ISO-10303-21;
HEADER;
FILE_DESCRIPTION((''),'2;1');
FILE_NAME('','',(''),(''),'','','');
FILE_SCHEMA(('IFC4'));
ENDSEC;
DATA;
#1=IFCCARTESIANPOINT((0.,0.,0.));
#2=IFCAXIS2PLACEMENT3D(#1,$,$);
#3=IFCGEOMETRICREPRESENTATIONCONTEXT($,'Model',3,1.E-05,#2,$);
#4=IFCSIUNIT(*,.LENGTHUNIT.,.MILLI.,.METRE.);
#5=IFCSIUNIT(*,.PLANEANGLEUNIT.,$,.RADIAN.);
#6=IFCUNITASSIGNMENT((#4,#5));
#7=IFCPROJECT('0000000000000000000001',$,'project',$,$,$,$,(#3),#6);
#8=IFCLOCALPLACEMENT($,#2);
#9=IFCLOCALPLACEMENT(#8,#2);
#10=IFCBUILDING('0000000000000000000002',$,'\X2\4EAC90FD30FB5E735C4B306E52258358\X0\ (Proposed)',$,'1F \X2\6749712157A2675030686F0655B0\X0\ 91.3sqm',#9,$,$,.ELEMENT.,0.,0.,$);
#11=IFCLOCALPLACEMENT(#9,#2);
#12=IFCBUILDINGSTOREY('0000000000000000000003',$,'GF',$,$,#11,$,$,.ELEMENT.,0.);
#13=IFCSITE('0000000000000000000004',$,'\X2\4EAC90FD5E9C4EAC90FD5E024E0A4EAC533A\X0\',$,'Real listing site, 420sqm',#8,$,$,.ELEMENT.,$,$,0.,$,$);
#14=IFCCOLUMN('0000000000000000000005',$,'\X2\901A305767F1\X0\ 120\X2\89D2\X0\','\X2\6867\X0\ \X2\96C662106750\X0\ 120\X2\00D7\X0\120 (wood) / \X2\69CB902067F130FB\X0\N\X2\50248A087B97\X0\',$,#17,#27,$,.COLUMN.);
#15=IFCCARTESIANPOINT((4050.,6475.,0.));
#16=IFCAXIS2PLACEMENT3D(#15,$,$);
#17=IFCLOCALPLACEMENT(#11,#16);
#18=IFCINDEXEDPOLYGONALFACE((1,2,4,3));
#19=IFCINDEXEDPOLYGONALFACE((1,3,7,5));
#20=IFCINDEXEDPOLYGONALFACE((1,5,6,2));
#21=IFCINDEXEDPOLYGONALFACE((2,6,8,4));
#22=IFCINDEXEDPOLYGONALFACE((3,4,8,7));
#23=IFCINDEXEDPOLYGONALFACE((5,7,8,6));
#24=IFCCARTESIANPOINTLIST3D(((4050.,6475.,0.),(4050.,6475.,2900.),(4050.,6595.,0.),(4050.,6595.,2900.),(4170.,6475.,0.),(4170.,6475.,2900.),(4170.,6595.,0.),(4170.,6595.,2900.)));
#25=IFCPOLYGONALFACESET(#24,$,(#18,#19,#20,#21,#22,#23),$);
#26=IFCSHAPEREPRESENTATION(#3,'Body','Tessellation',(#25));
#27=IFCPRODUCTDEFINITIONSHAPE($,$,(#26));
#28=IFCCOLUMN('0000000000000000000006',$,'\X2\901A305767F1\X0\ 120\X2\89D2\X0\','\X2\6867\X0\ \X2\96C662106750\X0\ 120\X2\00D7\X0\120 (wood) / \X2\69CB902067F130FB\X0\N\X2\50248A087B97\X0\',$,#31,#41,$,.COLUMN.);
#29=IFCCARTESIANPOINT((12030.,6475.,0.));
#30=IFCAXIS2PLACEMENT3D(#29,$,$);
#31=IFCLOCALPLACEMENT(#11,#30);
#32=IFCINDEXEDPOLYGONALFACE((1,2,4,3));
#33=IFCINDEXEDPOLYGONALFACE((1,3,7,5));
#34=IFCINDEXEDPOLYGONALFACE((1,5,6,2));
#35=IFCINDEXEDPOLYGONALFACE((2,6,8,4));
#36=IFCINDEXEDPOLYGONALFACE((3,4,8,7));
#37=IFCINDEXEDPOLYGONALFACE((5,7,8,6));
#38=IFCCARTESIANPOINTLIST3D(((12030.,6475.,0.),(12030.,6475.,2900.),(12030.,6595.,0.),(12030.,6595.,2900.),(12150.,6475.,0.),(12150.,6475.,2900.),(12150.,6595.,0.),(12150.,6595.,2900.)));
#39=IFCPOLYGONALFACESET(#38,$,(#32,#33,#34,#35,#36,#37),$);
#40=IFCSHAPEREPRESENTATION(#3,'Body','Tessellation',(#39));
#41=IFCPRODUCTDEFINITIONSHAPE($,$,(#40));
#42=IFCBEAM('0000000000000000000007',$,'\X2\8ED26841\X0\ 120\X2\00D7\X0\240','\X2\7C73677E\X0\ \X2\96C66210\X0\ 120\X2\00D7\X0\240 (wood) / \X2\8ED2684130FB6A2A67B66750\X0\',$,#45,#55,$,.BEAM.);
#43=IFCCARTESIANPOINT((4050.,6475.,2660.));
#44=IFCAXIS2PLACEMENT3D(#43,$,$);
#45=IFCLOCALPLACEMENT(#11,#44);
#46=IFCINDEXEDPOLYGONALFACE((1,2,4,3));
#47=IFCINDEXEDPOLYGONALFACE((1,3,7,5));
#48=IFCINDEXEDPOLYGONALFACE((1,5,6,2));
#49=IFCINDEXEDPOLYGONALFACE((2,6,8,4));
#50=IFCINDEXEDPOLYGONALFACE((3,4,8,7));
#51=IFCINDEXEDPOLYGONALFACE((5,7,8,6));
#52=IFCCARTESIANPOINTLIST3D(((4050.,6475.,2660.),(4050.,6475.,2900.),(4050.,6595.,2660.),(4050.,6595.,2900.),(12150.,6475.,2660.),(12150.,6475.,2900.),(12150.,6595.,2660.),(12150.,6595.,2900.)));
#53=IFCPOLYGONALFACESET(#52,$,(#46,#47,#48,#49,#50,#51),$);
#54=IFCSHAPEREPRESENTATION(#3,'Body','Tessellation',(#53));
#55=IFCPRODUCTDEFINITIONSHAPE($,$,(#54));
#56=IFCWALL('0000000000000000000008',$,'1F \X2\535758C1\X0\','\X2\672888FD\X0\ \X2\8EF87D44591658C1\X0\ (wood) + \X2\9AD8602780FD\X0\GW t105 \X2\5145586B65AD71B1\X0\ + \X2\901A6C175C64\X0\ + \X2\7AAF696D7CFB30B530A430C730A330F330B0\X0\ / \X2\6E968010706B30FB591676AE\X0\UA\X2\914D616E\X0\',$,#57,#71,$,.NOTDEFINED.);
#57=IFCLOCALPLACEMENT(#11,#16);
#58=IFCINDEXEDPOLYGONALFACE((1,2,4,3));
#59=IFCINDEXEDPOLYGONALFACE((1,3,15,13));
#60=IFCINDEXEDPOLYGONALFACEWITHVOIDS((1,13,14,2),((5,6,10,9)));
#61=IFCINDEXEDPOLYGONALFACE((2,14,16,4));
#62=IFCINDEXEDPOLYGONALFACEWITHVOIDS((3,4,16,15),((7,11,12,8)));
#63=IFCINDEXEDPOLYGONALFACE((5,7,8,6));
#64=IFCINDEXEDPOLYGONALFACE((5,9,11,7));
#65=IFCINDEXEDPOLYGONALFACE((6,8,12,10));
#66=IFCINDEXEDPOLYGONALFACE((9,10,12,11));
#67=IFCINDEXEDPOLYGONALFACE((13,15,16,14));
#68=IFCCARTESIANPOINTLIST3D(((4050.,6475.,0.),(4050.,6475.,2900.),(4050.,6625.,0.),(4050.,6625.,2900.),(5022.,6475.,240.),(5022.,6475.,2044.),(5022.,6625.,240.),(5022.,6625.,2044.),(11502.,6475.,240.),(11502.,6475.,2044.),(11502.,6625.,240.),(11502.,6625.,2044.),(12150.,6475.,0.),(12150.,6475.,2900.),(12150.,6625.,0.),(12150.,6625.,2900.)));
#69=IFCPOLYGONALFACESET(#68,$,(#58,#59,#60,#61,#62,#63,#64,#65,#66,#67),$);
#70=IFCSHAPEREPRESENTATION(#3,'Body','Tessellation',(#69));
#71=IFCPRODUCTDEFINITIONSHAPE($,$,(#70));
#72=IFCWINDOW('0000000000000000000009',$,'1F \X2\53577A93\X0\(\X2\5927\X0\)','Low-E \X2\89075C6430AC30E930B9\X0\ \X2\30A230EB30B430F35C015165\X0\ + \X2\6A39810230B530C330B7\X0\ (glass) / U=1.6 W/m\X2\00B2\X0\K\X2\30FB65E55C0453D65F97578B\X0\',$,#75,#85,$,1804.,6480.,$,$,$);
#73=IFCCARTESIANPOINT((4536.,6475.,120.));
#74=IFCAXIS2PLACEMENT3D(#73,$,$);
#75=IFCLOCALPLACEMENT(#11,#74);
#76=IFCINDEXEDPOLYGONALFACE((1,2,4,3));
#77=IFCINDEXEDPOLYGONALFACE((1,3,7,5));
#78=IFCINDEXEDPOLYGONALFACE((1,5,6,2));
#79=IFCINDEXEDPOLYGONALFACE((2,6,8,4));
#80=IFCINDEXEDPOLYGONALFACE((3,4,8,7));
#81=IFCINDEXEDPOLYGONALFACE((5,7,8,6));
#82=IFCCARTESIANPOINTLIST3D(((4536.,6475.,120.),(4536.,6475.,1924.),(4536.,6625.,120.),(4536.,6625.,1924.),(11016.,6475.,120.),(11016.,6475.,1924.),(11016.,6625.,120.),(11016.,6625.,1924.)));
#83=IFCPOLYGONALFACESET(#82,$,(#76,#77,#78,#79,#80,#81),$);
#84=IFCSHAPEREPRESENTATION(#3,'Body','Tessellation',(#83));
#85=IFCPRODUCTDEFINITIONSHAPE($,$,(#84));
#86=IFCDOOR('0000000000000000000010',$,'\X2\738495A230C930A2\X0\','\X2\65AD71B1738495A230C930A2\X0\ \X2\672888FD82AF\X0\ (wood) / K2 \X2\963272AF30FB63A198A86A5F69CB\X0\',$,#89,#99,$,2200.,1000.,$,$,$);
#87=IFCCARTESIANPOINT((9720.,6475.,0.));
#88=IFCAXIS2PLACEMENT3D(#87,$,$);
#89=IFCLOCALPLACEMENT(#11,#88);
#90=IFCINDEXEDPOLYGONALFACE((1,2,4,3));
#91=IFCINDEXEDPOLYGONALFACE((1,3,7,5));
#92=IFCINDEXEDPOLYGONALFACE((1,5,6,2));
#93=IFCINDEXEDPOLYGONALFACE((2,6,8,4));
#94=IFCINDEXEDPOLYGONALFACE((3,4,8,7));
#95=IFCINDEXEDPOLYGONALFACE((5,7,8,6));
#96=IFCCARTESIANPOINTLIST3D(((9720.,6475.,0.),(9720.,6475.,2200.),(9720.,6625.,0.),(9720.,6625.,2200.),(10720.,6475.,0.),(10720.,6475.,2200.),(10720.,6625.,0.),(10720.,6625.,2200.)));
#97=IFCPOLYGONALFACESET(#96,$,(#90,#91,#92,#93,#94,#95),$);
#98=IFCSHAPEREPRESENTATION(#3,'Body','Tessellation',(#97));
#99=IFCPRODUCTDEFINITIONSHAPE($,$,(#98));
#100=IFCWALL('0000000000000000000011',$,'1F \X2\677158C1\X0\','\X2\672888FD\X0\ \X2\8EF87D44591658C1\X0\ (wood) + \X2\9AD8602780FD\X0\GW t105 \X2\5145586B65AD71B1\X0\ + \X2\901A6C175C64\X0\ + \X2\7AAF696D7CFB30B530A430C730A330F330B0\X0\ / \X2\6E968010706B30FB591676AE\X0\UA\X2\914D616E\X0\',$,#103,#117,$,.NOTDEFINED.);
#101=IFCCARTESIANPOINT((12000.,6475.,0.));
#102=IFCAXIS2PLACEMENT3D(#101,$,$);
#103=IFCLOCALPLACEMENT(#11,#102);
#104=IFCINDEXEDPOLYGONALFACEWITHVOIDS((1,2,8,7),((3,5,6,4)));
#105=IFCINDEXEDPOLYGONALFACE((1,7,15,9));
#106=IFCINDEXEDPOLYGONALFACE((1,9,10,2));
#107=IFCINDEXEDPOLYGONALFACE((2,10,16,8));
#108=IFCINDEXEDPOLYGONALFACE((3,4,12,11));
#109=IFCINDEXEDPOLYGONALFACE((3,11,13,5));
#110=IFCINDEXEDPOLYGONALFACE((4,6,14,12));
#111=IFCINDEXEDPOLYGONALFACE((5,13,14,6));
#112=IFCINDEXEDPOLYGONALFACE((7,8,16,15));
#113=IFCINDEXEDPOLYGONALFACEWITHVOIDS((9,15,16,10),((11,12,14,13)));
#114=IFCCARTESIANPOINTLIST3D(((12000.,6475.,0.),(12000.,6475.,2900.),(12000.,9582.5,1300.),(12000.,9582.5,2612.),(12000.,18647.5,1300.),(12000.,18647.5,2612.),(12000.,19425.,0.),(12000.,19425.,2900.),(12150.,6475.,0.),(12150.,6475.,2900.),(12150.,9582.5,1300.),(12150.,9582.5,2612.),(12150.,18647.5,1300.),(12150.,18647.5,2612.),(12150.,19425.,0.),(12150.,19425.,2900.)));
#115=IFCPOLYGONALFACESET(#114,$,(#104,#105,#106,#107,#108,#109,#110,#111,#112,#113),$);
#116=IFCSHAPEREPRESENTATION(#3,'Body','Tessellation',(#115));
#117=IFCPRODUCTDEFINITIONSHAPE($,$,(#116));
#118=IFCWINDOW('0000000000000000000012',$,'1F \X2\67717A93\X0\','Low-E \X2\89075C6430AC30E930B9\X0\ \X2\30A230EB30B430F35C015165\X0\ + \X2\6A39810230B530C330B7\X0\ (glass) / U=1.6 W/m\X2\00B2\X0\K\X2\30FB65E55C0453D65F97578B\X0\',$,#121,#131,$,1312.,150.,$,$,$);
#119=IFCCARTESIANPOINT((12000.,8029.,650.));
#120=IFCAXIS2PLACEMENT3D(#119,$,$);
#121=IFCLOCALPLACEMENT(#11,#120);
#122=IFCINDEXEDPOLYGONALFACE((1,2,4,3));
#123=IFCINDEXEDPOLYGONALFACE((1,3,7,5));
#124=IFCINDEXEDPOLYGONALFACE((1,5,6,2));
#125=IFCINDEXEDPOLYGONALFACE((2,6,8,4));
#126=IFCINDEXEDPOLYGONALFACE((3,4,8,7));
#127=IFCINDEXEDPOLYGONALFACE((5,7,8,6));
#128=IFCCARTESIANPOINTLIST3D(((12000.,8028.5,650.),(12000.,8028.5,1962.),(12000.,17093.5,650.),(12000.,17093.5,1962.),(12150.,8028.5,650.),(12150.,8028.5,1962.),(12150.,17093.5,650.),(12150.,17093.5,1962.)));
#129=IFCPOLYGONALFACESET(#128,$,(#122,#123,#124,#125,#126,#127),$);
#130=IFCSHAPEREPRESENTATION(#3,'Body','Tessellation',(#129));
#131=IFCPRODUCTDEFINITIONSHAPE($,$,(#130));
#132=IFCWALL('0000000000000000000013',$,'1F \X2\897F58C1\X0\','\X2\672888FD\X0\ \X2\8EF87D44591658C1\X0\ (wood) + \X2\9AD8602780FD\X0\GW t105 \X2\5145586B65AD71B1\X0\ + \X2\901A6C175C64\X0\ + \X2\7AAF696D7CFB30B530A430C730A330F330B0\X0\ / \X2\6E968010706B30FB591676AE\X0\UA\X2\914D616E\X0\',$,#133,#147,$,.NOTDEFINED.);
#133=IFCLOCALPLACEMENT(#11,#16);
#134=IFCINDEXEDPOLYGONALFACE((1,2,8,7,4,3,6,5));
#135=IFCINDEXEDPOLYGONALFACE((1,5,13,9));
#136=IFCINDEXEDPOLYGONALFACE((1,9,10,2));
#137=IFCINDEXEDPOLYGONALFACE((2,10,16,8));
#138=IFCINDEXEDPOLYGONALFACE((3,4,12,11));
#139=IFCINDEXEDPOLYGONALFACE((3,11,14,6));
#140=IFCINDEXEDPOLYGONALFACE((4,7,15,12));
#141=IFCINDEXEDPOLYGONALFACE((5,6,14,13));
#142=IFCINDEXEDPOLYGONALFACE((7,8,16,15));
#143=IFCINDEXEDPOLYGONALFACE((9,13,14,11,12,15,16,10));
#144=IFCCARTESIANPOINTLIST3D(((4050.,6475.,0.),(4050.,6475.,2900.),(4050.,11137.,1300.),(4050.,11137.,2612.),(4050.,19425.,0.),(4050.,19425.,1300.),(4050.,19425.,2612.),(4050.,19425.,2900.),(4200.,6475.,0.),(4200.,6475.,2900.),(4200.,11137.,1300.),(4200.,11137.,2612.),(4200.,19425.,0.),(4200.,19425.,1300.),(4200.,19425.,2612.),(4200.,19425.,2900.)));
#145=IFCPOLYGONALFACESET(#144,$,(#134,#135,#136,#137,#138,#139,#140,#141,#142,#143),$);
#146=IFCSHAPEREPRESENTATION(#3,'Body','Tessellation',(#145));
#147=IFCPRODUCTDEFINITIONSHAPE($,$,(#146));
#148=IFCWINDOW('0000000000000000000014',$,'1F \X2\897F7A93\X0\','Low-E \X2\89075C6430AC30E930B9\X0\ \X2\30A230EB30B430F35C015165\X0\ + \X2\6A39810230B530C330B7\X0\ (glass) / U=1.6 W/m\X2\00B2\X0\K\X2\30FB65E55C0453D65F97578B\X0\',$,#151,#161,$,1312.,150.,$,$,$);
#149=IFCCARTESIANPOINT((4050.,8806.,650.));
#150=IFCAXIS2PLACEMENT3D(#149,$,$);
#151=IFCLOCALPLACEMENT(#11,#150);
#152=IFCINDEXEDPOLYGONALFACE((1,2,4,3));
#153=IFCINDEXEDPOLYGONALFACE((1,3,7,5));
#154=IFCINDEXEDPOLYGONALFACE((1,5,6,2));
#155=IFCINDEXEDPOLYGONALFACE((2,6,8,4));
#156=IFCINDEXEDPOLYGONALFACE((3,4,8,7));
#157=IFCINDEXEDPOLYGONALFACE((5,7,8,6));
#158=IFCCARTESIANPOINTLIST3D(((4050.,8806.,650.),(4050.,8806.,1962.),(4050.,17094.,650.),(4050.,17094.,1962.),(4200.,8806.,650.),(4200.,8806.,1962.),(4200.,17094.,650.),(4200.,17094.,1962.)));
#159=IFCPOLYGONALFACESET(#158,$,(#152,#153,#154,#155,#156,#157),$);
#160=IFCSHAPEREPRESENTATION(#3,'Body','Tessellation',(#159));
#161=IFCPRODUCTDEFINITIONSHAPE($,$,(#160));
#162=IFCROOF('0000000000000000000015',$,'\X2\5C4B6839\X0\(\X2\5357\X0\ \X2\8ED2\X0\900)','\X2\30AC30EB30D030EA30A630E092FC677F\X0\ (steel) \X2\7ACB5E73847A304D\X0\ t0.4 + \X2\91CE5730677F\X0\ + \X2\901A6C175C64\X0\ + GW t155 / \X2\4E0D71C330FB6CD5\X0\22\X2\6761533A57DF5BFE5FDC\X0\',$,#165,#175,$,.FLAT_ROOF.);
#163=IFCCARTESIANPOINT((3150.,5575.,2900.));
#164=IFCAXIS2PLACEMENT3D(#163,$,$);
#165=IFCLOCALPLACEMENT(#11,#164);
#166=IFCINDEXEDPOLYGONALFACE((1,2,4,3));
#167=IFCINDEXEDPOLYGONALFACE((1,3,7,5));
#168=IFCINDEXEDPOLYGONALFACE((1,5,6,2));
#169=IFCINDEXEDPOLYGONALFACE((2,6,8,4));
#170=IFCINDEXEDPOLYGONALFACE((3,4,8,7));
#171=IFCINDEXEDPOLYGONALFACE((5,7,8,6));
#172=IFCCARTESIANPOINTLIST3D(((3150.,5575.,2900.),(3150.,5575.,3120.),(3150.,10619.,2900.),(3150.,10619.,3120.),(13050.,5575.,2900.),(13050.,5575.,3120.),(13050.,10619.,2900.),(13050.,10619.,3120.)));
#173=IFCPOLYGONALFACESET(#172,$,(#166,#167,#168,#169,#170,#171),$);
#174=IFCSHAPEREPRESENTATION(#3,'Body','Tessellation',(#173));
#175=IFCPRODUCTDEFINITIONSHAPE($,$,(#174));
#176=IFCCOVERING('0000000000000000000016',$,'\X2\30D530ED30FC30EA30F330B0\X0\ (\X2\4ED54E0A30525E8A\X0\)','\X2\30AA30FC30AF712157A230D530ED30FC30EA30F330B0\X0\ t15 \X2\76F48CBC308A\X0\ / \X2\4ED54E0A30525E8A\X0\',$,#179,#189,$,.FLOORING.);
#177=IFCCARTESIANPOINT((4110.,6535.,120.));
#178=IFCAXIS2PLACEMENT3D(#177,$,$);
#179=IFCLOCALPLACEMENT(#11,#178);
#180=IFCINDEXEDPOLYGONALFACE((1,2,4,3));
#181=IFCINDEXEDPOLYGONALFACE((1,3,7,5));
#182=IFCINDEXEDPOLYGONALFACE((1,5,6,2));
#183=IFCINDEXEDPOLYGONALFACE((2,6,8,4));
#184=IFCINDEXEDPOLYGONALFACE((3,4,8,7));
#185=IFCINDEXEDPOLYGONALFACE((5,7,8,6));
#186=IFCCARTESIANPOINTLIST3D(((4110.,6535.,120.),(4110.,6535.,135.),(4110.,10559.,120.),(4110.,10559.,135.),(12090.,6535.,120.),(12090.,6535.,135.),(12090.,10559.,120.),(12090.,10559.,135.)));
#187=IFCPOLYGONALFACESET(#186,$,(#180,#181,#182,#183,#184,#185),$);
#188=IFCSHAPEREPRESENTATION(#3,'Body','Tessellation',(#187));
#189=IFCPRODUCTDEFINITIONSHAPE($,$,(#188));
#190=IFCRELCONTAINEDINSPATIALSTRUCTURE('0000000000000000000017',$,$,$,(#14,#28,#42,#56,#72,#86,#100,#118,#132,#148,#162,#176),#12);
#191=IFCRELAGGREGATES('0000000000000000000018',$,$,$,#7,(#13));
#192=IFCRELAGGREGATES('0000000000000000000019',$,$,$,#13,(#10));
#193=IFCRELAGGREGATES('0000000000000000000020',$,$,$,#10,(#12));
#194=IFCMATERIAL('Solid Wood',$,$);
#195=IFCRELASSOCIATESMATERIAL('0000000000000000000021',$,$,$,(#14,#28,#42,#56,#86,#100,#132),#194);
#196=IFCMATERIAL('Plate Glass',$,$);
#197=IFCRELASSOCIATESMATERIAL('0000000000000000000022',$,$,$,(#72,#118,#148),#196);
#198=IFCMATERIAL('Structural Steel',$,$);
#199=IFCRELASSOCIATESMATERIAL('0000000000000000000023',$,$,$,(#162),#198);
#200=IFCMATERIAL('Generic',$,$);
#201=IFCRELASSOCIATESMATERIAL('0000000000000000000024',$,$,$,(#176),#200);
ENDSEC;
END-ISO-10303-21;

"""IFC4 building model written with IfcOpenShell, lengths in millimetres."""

from ifc_helpers import new_model, si_unit, frame, frame_2d, origin, place, context, project, spatial, rectangle, extrude, material, element, fill, save


model = new_model("IFC4")

# Units and contexts
model_context = context("Model", 3, precision=1e-05, world=origin())
ifc_project = project(units=[si_unit("LENGTHUNIT", "METRE", prefix="MILLI"), si_unit("PLANEANGLEUNIT", "RADIAN")], contexts=[model_context])

# Site, building, storey
site_placement = place(None, origin())
site = spatial("IfcSite", under=ifc_project, at=site_placement, Name="京都府京都市上京区", ObjectType="Real listing site, 420sqm", CompositionType="ELEMENT", RefElevation=0.0)
building_placement = place(site_placement, origin())
building = spatial("IfcBuilding", under=site, at=building_placement, Name="京都・平屋の別荘 (Proposed)", ObjectType="1F 杉無垢材と漆喰 91.3sqm", CompositionType="ELEMENT", ElevationOfRefHeight=0.0, ElevationOfTerrain=0.0)
storey_placement = place(building_placement, origin())
storey = spatial("IfcBuildingStorey", under=building, at=storey_placement, Name="GF", CompositionType="ELEMENT", Elevation=0.0)

# Columns
ifc_material_1 = material(Name="Solid Wood")
column_1_placement = place(storey_placement, frame((4050.0, 6475.0, 0.0)))
element("IfcColumn", 1, at=column_1_placement, inside=storey, material=ifc_material_1, Name="通し柱 120角", Description="桧 集成材 120×120 (wood) / 構造柱・N値計算", PredefinedType="COLUMN", context=model_context, shape_type="SweptSolid", body=[
    extrude(rectangle(XDim=120.0, YDim=120.0, at=frame_2d((60.0, 60.0))), frame((4050.0, 6475.0, 0.0)), (0.0, 0.0, 1.0), 2900.0),
])
column_2_placement = place(storey_placement, frame((12030.0, 6475.0, 0.0)))
element("IfcColumn", 2, at=column_2_placement, inside=storey, material=ifc_material_1, Name="通し柱 120角", Description="桧 集成材 120×120 (wood) / 構造柱・N値計算", PredefinedType="COLUMN", context=model_context, shape_type="SweptSolid", body=[
    extrude(rectangle(XDim=120.0, YDim=120.0, at=frame_2d((60.0, 60.0))), frame((12030.0, 6475.0, 0.0)), (0.0, 0.0, 1.0), 2900.0),
])

# Beam
beam_1_placement = place(storey_placement, frame((4050.0, 6475.0, 2660.0)))
element("IfcBeam", 3, at=beam_1_placement, inside=storey, material=ifc_material_1, Name="軒桁 120×240", Description="米松 集成 120×240 (wood) / 軒桁・横架材", PredefinedType="BEAM", context=model_context, shape_type="SweptSolid", body=[
    extrude(rectangle(XDim=8100.0, YDim=120.0, at=frame_2d((4050.0, 60.0))), frame((4050.0, 6475.0, 2660.0)), (0.0, 0.0, 1.0), 240.0),
])

# Wall, openings, window, door
wall_1_placement = place(storey_placement, frame((4050.0, 6475.0, 0.0)))
wall_1 = element("IfcWall", 4, at=wall_1_placement, inside=storey, material=ifc_material_1, Name="1F 南壁", Description="木製 軸組外壁 (wood) + 高性能GW t105 充填断熱 + 通気層 + 窯業系サイディング / 準耐火・外皮UA配慮", PredefinedType="NOTDEFINED", context=model_context, shape_type="SweptSolid", body=[
    extrude(rectangle(XDim=8100.0, YDim=150.0, at=frame_2d((4050.0, 75.0))), frame((4050.0, 6475.0, 0.0)), (0.0, 0.0, 1.0), 2900.0),
])
opening_1_placement = place(storey_placement, frame((4536.0, 6475.0, 120.0)))
opening_1 = element("IfcOpeningElement", 5, at=opening_1_placement, cuts=wall_1, PredefinedType="NOTDEFINED", context=model_context, shape_type="SweptSolid", body=[
    extrude(rectangle(XDim=6480.0, YDim=150.0, at=frame_2d((3240.0, 75.0))), frame((4536.0, 6475.0, 120.0)), (0.0, 0.0, 1.0), 1804.0),
])
opening_2_placement = place(storey_placement, frame((9720.0, 6475.0, 0.0)))
opening_2 = element("IfcOpeningElement", 6, at=opening_2_placement, cuts=wall_1, PredefinedType="NOTDEFINED", context=model_context, shape_type="SweptSolid", body=[
    extrude(rectangle(XDim=1000.0, YDim=150.0, at=frame_2d((500.0, 75.0))), frame((9720.0, 6475.0, 0.0)), (0.0, 0.0, 1.0), 2200.0),
])
ifc_material_2 = material(Name="Plate Glass")
window_1_placement = place(storey_placement, frame((4536.0, 6475.0, 120.0)))
window_1 = element("IfcWindow", 7, at=window_1_placement, inside=storey, material=ifc_material_2, Name="1F 南窓(大)", Description="Low-E 複層ガラス アルゴン封入 + 樹脂サッシ (glass) / U=1.6 W/m²K・日射取得型", OverallHeight=1804.0, OverallWidth=6480.0, context=model_context, shape_type="SweptSolid", body=[
    extrude(rectangle(XDim=6480.0, YDim=150.0, at=frame_2d((3240.0, 75.0))), frame((4536.0, 6475.0, 120.0)), (0.0, 0.0, 1.0), 1804.0),
])
fill(opening_1, window_1)
door_placement = place(storey_placement, frame((9720.0, 6475.0, 0.0)))
door = element("IfcDoor", 8, at=door_placement, inside=storey, material=ifc_material_1, Name="玄関ドア", Description="断熱玄関ドア 木製芯 (wood) / K2 防犯・採風機構", OverallHeight=2200.0, OverallWidth=1000.0, context=model_context, shape_type="SweptSolid", body=[
    extrude(rectangle(XDim=1000.0, YDim=150.0, at=frame_2d((500.0, 75.0))), frame((9720.0, 6475.0, 0.0)), (0.0, 0.0, 1.0), 2200.0),
])
fill(opening_2, door)

# Walls, openings, windows
wall_2_placement = place(storey_placement, frame((12000.0, 6475.0, 0.0)))
wall_2 = element("IfcWall", 9, at=wall_2_placement, inside=storey, material=ifc_material_1, Name="1F 東壁", Description="木製 軸組外壁 (wood) + 高性能GW t105 充填断熱 + 通気層 + 窯業系サイディング / 準耐火・外皮UA配慮", PredefinedType="NOTDEFINED", context=model_context, shape_type="SweptSolid", body=[
    extrude(rectangle(XDim=150.0, YDim=12950.0, at=frame_2d((75.0, 6475.0))), frame((12000.0, 6475.0, 0.0)), (0.0, 0.0, 1.0), 2900.0),
])
opening_3_placement = place(storey_placement, frame((12000.0, 8029.0, 650.0)))
opening_3 = element("IfcOpeningElement", 10, at=opening_3_placement, cuts=wall_2, PredefinedType="NOTDEFINED", context=model_context, shape_type="SweptSolid", body=[
    extrude(rectangle(XDim=150.0, YDim=9065.0, at=frame_2d((75.0, 4532.0))), frame((12000.0, 8029.0, 650.0)), (0.0, 0.0, 1.0), 1312.0),
])
window_2_placement = place(storey_placement, frame((12000.0, 8029.0, 650.0)))
window_2 = element("IfcWindow", 11, at=window_2_placement, inside=storey, material=ifc_material_2, Name="1F 東窓", Description="Low-E 複層ガラス アルゴン封入 + 樹脂サッシ (glass) / U=1.6 W/m²K・日射取得型", OverallHeight=1312.0, OverallWidth=150.0, context=model_context, shape_type="SweptSolid", body=[
    extrude(rectangle(XDim=150.0, YDim=9065.0, at=frame_2d((75.0, 4532.0))), frame((12000.0, 8029.0, 650.0)), (0.0, 0.0, 1.0), 1312.0),
])
fill(opening_3, window_2)
wall_3_placement = place(storey_placement, frame((4050.0, 6475.0, 0.0)))
wall_3 = element("IfcWall", 12, at=wall_3_placement, inside=storey, material=ifc_material_1, Name="1F 西壁", Description="木製 軸組外壁 (wood) + 高性能GW t105 充填断熱 + 通気層 + 窯業系サイディング / 準耐火・外皮UA配慮", PredefinedType="NOTDEFINED", context=model_context, shape_type="SweptSolid", body=[
    extrude(rectangle(XDim=150.0, YDim=12950.0, at=frame_2d((75.0, 6475.0))), frame((4050.0, 6475.0, 0.0)), (0.0, 0.0, 1.0), 2900.0),
])
opening_4_placement = place(storey_placement, frame((4050.0, 8806.0, 650.0)))
opening_4 = element("IfcOpeningElement", 13, at=opening_4_placement, cuts=wall_3, PredefinedType="NOTDEFINED", context=model_context, shape_type="SweptSolid", body=[
    extrude(rectangle(XDim=150.0, YDim=8288.0, at=frame_2d((75.0, 4144.0))), frame((4050.0, 8806.0, 650.0)), (0.0, 0.0, 1.0), 1312.0),
])
window_3_placement = place(storey_placement, frame((4050.0, 8806.0, 650.0)))
window_3 = element("IfcWindow", 14, at=window_3_placement, inside=storey, material=ifc_material_2, Name="1F 西窓", Description="Low-E 複層ガラス アルゴン封入 + 樹脂サッシ (glass) / U=1.6 W/m²K・日射取得型", OverallHeight=1312.0, OverallWidth=150.0, context=model_context, shape_type="SweptSolid", body=[
    extrude(rectangle(XDim=150.0, YDim=8288.0, at=frame_2d((75.0, 4144.0))), frame((4050.0, 8806.0, 650.0)), (0.0, 0.0, 1.0), 1312.0),
])
fill(opening_4, window_3)

# Roof
ifc_material_3 = material(Name="Structural Steel")
roof_placement = place(storey_placement, frame((3150.0, 5575.0, 2900.0)))
element("IfcRoof", 15, at=roof_placement, inside=storey, material=ifc_material_3, Name="屋根(南 軒900)", Description="ガルバリウム鋼板 (steel) 立平葺き t0.4 + 野地板 + 通気層 + GW t155 / 不燃・法22条区域対応", PredefinedType="FLAT_ROOF", context=model_context, shape_type="SweptSolid", body=[
    extrude(rectangle(XDim=9900.0, YDim=5044.0, at=frame_2d((4950.0, 2522.0))), frame((3150.0, 5575.0, 2900.0)), (0.0, 0.0, 1.0), 220.0),
])

# Covering
ifc_material_4 = material(Name="Generic")
covering_1_placement = place(storey_placement, frame((4110.0, 6535.0, 120.0)))
element("IfcCovering", 16, at=covering_1_placement, inside=storey, material=ifc_material_4, Name="フローリング (仕上げ床)", Description="オーク無垢フローリング t15 直貼り / 仕上げ床", PredefinedType="FLOORING", context=model_context, shape_type="SweptSolid", body=[
    extrude(rectangle(XDim=7980.0, YDim=4024.0, at=frame_2d((3990.0, 2012.0))), frame((4110.0, 6535.0, 120.0)), (0.0, 0.0, 1.0), 15.0),
])

save(model, "model.ifc")
